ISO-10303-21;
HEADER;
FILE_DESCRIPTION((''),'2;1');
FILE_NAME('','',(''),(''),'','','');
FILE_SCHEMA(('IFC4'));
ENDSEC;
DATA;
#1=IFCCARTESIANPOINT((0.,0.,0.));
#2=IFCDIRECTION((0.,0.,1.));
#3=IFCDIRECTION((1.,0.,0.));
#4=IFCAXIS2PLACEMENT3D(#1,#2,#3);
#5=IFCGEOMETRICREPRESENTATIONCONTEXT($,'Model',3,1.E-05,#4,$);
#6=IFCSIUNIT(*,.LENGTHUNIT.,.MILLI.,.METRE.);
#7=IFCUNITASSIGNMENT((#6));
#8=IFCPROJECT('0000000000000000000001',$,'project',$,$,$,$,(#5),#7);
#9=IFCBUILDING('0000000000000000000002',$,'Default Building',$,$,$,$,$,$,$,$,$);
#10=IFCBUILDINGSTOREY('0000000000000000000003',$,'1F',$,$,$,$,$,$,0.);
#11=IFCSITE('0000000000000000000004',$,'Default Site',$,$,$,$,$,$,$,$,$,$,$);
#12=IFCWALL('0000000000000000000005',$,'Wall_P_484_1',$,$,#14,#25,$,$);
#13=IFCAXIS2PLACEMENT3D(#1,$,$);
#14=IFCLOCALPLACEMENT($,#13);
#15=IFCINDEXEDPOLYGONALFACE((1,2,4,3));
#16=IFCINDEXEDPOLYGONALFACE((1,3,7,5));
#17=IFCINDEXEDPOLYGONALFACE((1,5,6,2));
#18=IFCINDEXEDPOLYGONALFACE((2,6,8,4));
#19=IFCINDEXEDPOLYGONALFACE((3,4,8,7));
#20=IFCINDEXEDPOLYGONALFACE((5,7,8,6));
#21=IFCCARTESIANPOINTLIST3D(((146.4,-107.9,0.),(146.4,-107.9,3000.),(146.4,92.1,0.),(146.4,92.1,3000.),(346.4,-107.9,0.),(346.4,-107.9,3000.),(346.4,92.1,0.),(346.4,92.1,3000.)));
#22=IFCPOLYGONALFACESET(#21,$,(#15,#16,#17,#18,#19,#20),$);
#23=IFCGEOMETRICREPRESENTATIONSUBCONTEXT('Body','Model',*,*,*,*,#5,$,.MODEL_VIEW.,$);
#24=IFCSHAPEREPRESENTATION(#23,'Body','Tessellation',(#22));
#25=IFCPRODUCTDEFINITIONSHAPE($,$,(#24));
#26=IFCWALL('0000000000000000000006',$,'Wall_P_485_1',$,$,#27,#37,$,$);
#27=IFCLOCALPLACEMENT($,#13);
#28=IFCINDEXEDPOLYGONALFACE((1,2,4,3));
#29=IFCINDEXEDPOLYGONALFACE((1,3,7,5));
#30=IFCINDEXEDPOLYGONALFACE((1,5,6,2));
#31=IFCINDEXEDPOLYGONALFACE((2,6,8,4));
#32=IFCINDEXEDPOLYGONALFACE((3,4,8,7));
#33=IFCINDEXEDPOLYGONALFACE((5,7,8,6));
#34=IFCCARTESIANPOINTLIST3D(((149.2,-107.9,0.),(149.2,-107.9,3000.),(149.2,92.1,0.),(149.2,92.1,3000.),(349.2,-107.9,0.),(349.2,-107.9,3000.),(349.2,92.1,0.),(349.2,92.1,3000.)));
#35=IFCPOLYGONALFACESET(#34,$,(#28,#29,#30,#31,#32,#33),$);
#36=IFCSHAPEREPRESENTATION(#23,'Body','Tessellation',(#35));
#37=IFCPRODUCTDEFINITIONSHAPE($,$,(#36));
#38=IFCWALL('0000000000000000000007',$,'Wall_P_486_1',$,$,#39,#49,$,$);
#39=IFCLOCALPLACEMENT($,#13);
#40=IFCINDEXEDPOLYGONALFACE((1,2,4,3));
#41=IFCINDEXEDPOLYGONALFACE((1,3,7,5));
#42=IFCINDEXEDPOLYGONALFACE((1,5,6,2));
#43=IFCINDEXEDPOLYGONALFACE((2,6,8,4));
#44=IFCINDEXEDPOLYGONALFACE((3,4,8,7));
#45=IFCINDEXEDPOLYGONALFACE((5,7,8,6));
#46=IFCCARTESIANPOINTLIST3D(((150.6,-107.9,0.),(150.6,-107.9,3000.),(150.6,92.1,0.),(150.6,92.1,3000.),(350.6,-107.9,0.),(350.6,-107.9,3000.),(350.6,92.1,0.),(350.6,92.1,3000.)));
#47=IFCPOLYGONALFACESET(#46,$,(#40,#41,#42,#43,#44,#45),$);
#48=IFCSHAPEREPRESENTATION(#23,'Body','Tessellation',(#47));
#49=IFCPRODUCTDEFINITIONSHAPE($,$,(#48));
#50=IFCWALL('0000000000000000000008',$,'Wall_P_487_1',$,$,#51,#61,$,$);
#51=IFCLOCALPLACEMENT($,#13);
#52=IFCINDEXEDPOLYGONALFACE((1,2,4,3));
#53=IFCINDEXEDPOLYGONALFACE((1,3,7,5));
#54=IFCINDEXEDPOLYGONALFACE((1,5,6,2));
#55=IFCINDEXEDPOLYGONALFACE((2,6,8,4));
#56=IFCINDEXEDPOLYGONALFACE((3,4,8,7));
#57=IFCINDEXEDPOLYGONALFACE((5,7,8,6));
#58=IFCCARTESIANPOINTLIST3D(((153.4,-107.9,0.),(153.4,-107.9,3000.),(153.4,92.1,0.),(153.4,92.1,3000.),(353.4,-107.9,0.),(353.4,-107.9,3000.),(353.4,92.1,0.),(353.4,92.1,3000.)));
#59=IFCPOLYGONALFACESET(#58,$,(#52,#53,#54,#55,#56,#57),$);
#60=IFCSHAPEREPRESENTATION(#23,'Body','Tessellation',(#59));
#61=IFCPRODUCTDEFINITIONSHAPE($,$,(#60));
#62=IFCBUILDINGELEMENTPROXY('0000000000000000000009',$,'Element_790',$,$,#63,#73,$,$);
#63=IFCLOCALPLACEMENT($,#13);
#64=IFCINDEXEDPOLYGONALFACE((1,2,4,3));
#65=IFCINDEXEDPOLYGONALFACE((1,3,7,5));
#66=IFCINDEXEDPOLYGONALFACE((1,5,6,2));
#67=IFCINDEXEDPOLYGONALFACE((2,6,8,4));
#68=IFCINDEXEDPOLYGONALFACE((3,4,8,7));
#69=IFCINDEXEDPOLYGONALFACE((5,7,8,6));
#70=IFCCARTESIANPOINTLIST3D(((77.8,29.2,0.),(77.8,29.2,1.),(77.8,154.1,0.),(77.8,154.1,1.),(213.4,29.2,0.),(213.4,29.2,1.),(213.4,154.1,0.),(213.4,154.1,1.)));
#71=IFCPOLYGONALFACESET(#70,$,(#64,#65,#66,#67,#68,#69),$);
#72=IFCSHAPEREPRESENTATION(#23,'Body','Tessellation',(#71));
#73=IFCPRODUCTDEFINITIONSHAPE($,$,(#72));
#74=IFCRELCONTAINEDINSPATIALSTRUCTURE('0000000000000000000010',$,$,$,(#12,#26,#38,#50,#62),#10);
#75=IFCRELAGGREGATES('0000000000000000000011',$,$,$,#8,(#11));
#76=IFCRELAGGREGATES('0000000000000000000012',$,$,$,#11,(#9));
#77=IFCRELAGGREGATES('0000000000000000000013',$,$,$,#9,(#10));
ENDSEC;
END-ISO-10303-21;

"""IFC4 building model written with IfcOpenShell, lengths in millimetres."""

from ifc_helpers import new_model, si_unit, frame, origin, origin_with_axes, place, context, subcontext, project, spatial, polyline, indexed_curve, outline, extrude, element, save


model = new_model("IFC4")

# Units and contexts
model_context = context("Model", 3, precision=1e-05, world=origin_with_axes())
body_context = subcontext(model_context, "Body", "Model", "MODEL_VIEW")
ifc_project = project(units=[si_unit("LENGTHUNIT", "METRE", prefix="MILLI")], contexts=[model_context])

# Site, building, storey
site = spatial("IfcSite", under=ifc_project, Name="Default Site")
building = spatial("IfcBuilding", under=site, Name="Default Building")
storey = spatial("IfcBuildingStorey", under=building, Name="1F", Elevation=0.0)

# Walls
for number, where, z_axis, x_axis, name in (
    (1, (146.4, 92.1, 0.0), (0.0, 0.0, 1.0), (0.0, -1.0, 0.0), "Wall_P_484_1"),
    (2, (149.2, 92.1, 0.0), (0.0, 0.0, 1.0), (0.0, -1.0, 0.0), "Wall_P_485_1"),
    (3, (150.6, 92.1, 0.0), (0.0, 0.0, 1.0), (0.0, -1.0, 0.0), "Wall_P_486_1"),
    (4, (153.4, 92.1, 0.0), (0.0, 0.0, 1.0), (0.0, -1.0, 0.0), "Wall_P_487_1"),
):
    element("IfcWall", number, at=place(None, frame(where, z_axis=z_axis, x_axis=x_axis)), inside=storey, Name=name, context=body_context, shape_type="SweptSolid", body=[
        extrude(outline(indexed_curve([(0.0, 0.0), (0.0, 200.0), (200.0, 200.0), (200.0, 0.0), (0.0, 0.0)], self_intersect=False)), origin_with_axes(), (0.0, 0.0, 1.0), 3000.0),
    ])

# Building element proxy
proxy_1_placement = place(None, frame((145.6, 91.7, 0.0), z_axis=(0.0, 0.0, 1.0), x_axis=(1.0, 0.0, 0.0)))
element("IfcBuildingElementProxy", 5, at=proxy_1_placement, inside=storey, Name="Element_790", context=body_context, shape_type="SweptSolid", body=[
    extrude(outline(polyline([(-67.8, 62.5), (67.8, 62.5), (67.8, -62.5), (-67.8, -62.5), (-67.8, 62.5)])), origin(), (0.0, 0.0, 1.0), 1.0),
])

save(model, "model.ifc")
